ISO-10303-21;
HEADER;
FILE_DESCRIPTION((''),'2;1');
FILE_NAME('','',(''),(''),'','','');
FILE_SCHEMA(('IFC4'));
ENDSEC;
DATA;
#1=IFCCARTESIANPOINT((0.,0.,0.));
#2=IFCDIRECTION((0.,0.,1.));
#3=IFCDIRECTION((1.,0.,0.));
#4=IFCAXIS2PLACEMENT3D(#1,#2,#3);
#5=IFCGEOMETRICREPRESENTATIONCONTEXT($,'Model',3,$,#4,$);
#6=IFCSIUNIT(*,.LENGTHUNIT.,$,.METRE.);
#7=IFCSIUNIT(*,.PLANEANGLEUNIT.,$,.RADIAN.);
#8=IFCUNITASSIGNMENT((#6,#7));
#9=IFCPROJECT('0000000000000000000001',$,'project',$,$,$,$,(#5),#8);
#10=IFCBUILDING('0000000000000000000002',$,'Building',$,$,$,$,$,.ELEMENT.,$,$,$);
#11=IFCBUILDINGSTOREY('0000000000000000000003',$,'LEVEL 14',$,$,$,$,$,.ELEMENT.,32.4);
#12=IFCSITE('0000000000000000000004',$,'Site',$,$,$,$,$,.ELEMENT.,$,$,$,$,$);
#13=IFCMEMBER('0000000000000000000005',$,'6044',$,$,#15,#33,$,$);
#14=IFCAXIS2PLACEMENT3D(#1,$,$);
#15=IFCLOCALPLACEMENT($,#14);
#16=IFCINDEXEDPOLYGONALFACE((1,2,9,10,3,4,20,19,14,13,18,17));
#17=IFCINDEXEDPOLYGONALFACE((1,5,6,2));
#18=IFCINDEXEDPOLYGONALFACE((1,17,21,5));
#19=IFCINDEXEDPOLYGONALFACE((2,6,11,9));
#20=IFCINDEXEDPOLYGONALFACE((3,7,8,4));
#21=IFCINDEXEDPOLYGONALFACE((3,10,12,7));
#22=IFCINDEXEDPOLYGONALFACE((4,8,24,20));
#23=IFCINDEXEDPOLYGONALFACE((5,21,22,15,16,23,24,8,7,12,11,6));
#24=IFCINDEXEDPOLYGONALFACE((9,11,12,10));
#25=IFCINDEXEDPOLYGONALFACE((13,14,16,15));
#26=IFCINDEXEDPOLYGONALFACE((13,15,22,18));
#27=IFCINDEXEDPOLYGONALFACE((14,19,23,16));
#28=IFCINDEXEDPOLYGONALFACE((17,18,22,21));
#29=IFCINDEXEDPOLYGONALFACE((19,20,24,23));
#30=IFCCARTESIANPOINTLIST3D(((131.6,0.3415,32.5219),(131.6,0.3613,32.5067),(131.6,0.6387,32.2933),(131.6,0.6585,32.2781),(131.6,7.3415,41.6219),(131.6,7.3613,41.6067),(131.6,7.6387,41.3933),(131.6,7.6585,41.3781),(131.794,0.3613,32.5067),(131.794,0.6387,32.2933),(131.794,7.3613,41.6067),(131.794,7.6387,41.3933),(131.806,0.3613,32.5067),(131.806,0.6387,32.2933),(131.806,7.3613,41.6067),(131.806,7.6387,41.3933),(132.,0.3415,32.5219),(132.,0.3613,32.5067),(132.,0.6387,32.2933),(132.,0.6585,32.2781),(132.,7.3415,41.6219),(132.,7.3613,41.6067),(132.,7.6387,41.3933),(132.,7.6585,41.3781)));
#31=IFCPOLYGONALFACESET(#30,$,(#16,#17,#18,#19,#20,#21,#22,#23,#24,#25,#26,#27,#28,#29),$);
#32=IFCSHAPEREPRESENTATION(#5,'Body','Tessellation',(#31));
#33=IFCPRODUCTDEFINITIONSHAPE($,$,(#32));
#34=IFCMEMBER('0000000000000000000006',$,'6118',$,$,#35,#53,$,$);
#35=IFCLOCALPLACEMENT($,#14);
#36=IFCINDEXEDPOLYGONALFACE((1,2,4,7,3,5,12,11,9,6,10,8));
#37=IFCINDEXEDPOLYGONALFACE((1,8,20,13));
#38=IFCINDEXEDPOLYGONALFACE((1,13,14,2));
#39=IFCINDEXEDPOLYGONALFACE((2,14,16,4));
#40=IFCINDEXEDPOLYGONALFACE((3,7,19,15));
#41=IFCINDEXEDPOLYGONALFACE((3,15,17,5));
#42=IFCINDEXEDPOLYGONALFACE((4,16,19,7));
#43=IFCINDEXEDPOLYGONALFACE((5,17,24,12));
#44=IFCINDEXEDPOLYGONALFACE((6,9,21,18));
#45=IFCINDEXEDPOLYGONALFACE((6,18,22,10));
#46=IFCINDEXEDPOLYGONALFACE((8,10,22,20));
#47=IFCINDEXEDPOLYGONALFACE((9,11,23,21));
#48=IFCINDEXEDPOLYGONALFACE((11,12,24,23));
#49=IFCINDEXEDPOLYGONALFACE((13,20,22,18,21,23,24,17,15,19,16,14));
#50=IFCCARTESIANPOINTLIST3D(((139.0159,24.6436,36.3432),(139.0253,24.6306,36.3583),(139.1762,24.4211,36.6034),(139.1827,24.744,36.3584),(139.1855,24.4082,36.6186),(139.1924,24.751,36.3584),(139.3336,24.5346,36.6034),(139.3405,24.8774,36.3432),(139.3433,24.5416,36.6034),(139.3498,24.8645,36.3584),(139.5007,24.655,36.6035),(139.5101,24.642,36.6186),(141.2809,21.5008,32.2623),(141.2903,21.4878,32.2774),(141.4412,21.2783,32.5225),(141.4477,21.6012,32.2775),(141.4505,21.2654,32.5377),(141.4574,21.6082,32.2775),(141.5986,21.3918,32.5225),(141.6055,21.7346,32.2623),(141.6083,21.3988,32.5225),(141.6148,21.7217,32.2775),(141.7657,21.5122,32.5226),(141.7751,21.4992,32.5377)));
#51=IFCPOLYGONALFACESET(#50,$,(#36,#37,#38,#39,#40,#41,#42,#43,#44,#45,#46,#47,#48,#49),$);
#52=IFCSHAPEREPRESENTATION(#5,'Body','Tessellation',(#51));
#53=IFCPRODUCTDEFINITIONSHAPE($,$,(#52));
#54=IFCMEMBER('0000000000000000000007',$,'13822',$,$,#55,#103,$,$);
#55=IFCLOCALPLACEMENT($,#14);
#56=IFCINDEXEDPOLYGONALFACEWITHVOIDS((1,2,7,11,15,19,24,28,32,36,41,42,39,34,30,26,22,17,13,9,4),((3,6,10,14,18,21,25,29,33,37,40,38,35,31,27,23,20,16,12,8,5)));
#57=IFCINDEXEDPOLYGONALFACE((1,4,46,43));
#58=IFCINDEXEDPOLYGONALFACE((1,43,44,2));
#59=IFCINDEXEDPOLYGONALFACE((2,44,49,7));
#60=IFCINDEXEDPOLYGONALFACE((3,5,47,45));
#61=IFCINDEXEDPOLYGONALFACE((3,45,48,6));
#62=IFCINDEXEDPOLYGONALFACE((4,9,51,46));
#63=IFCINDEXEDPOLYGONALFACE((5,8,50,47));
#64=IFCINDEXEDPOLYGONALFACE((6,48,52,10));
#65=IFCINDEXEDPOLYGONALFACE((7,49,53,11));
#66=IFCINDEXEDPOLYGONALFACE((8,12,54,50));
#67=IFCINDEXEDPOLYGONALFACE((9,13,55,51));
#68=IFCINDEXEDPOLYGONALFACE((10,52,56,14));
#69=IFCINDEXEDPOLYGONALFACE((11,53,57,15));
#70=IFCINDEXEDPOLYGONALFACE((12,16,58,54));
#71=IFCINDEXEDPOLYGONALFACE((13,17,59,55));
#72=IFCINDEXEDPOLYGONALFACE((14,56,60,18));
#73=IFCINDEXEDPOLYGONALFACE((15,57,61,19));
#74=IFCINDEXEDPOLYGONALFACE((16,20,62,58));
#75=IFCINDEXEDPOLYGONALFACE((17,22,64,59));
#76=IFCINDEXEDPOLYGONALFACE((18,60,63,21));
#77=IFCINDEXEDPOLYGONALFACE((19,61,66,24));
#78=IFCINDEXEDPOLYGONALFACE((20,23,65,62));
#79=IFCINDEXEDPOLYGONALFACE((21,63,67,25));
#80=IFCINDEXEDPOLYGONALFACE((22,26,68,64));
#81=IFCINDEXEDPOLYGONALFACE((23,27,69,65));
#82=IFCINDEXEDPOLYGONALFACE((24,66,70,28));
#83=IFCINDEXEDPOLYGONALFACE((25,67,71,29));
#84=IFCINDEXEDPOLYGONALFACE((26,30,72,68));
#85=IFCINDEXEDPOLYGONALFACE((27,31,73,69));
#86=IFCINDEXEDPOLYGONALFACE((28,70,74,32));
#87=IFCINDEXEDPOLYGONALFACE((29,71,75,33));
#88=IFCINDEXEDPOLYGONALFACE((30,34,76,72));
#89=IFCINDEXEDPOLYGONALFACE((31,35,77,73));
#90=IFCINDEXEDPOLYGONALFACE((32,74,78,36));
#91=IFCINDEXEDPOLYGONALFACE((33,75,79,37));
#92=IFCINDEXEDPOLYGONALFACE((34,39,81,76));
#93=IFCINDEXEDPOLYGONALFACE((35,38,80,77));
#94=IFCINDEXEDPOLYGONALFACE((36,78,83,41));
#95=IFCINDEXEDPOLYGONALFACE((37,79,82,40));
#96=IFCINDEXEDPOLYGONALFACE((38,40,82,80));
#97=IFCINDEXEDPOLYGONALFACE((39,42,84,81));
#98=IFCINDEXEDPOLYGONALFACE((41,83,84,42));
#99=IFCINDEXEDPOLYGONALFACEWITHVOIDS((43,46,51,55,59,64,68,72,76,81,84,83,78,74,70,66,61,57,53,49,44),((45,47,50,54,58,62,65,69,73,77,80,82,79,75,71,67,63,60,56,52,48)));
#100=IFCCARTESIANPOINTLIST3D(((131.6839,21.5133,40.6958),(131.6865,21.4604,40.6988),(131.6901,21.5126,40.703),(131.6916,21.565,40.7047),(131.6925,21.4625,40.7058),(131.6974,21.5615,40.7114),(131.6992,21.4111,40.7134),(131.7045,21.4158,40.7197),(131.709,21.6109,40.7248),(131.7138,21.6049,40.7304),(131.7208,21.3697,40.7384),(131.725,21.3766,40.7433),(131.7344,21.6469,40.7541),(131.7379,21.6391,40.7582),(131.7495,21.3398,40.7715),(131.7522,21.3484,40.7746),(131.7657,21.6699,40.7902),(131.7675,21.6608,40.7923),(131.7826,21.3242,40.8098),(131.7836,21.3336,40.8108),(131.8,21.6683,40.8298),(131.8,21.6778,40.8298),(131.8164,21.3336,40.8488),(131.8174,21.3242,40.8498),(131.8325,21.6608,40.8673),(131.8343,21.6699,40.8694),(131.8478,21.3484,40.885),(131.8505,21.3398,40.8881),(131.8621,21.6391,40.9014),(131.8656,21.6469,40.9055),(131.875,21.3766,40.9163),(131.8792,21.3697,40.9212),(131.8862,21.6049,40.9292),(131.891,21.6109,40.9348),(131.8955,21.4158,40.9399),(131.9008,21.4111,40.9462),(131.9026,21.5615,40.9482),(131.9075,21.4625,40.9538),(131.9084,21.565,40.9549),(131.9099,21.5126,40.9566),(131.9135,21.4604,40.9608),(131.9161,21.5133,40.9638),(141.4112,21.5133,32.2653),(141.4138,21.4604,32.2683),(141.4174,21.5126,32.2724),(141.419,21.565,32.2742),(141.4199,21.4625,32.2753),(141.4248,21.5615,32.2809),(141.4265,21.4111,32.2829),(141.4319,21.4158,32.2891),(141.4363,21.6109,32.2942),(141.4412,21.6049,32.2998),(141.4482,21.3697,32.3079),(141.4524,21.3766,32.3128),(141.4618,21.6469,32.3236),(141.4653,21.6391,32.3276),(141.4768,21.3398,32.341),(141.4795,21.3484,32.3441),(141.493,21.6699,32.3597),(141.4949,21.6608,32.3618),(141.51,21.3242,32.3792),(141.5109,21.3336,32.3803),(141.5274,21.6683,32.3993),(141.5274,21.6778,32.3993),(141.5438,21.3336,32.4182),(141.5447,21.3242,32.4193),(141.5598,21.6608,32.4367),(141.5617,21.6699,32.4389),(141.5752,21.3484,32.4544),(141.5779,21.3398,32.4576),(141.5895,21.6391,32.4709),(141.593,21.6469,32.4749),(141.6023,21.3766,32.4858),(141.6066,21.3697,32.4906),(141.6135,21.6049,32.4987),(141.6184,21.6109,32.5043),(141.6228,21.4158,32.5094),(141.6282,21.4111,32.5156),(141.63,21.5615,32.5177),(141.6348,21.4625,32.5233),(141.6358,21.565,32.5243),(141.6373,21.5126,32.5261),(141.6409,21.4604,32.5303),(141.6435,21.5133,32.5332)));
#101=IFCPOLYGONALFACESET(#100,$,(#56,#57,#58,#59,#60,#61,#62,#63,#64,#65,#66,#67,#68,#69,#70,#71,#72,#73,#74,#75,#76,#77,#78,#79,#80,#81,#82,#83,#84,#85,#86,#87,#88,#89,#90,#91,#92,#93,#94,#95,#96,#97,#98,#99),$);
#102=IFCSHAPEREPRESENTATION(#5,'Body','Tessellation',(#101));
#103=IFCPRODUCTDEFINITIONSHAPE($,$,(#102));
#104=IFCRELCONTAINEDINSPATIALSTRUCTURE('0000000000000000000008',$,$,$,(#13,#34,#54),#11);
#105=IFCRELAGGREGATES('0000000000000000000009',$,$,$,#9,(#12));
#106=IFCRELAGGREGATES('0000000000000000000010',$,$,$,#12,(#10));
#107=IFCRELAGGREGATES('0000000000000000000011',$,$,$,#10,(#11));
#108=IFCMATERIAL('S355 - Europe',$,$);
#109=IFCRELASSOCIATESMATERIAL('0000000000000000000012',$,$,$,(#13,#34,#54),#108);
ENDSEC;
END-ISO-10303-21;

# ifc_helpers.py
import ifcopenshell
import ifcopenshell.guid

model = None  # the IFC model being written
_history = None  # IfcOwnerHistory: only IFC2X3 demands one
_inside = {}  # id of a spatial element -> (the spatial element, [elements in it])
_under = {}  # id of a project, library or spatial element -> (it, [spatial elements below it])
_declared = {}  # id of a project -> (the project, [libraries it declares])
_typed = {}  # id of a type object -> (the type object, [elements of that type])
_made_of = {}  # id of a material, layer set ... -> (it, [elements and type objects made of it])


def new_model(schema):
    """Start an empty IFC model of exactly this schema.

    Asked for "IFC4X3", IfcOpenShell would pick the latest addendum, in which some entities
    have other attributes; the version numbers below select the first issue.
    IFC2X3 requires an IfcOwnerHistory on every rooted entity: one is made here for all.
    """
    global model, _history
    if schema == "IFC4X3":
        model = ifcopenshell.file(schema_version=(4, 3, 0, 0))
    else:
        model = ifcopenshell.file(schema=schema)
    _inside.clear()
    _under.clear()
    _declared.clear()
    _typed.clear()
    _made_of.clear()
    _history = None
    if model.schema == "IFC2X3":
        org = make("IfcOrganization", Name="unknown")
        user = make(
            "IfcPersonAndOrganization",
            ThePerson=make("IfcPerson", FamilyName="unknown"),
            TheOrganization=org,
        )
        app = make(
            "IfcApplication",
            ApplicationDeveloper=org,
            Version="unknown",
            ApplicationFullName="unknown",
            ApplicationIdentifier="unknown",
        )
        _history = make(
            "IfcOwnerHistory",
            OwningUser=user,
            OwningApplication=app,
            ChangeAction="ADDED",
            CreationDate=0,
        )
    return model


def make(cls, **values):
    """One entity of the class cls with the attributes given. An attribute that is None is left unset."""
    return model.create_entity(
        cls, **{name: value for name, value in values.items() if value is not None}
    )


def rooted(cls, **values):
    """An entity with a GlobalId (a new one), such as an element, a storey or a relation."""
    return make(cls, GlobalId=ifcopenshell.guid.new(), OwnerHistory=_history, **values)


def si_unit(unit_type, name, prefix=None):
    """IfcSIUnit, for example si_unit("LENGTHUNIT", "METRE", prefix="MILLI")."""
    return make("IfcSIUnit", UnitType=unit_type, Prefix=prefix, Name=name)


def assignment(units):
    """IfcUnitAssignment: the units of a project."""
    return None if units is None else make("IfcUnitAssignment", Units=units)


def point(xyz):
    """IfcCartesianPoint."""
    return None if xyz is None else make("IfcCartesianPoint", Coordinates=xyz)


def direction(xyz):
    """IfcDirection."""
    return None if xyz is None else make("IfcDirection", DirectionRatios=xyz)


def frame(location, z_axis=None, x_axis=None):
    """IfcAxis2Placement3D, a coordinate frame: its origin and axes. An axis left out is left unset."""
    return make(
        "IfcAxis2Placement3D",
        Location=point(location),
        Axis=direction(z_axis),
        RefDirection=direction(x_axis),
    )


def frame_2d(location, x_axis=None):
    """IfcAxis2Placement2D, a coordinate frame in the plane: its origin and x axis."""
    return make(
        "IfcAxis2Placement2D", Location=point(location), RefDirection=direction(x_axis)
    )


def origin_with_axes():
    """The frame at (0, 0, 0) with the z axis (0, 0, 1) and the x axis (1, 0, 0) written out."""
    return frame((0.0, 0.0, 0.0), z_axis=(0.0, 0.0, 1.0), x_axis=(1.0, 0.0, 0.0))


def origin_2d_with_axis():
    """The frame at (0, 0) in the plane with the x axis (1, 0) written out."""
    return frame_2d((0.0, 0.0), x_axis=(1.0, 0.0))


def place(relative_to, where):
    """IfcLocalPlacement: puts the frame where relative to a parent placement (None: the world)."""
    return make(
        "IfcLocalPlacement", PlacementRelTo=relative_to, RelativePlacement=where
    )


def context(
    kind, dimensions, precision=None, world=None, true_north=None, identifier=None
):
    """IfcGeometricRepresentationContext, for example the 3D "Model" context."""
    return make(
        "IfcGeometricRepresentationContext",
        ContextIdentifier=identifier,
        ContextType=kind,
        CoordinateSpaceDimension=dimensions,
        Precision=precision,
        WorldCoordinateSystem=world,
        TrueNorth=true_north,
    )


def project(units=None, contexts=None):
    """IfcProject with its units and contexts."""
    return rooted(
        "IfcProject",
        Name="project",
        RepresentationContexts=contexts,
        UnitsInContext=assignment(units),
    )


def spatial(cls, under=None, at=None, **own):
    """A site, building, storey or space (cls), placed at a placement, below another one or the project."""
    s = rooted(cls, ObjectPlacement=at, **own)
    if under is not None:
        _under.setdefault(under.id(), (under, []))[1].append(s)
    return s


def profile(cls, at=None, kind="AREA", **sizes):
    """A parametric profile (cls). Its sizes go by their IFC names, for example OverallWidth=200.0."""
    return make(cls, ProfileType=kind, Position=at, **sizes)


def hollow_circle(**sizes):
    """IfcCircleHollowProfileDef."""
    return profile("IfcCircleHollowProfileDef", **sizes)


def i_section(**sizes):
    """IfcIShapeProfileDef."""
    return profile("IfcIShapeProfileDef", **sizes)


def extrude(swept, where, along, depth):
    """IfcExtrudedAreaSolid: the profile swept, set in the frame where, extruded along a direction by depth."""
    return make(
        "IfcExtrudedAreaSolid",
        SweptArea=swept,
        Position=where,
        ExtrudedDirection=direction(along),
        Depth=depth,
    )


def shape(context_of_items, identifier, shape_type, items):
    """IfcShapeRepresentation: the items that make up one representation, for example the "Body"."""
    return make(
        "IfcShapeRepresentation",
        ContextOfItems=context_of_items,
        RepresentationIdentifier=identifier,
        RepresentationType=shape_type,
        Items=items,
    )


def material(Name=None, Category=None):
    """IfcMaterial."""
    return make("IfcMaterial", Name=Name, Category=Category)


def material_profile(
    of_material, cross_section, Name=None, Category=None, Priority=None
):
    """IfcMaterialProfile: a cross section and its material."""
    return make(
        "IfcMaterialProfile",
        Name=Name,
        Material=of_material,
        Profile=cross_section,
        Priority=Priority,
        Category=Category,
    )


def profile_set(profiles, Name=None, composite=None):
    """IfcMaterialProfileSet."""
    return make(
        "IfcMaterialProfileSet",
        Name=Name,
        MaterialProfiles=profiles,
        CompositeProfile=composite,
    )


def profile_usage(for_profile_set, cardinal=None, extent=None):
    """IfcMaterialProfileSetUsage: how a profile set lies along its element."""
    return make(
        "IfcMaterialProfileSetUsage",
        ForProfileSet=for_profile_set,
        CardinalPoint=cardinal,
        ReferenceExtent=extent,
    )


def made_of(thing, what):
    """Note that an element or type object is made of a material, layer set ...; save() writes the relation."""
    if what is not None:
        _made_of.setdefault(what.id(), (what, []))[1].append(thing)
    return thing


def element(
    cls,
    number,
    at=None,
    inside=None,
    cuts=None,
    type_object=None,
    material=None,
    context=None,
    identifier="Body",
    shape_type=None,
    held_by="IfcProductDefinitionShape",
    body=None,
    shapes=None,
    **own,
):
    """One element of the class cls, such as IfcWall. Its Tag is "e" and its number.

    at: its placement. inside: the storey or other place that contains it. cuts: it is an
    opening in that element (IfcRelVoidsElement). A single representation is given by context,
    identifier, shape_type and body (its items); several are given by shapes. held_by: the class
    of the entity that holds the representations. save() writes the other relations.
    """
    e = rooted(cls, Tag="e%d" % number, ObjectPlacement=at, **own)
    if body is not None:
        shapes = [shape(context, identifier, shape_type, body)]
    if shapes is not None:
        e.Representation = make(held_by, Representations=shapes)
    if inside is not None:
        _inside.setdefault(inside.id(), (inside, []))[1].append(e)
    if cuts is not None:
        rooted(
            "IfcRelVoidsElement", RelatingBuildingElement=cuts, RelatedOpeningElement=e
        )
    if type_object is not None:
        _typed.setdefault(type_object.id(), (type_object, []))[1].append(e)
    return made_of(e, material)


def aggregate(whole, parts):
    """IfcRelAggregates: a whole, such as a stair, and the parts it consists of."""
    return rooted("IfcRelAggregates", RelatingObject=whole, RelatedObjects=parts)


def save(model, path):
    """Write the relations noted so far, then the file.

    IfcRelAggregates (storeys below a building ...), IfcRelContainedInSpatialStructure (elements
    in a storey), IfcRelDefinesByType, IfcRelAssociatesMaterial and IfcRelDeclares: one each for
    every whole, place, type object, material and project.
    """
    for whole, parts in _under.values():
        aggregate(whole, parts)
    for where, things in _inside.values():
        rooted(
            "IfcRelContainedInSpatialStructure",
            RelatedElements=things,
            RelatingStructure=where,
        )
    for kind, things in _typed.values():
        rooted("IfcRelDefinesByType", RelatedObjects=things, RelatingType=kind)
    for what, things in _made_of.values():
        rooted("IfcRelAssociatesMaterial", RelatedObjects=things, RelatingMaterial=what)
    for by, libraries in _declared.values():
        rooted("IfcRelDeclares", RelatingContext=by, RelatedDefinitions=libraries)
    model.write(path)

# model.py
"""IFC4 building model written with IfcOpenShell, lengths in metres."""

from ifc_helpers import new_model, si_unit, frame, origin_with_axes, origin_2d_with_axis, place, context, project, spatial, hollow_circle, i_section, extrude, material, material_profile, profile_set, profile_usage, element, save


model = new_model("IFC4")

# Units and contexts
model_context = context("Model", 3, world=origin_with_axes())
ifc_project = project(units=[si_unit("LENGTHUNIT", "METRE"), si_unit("PLANEANGLEUNIT", "RADIAN")], contexts=[model_context])

# Site, building, storey
site = spatial("IfcSite", under=ifc_project, Name="Site", CompositionType="ELEMENT")
building = spatial("IfcBuilding", under=site, Name="Building", CompositionType="ELEMENT")
storey = spatial("IfcBuildingStorey", under=building, Name="LEVEL 14", CompositionType="ELEMENT", Elevation=32.4)

# Shared definitions
ifc_material = material(Name="S355 - Europe")

# Members
ifc_material_profile_1 = material_profile(ifc_material, i_section(OverallWidth=0.4, OverallDepth=0.4, WebThickness=0.012, FlangeThickness=0.025, at=origin_2d_with_axis()))
ifc_profile_set_1 = profile_set([ifc_material_profile_1])
ifc_profile_usage_1 = profile_usage(ifc_profile_set_1, cardinal=10)
member_1_placement = place(None, frame((131.8, 0.5, 32.4), z_axis=(0.0, 0.609711, 0.792624), x_axis=(-1.0, 0.0, 0.0)))
element("IfcMember", 1, at=member_1_placement, inside=storey, material=ifc_profile_usage_1, Name="6044", context=model_context, shape_type="SweptSolid", body=[
    extrude(i_section(OverallWidth=0.4, OverallDepth=0.4, WebThickness=0.012, FlangeThickness=0.025, at=origin_2d_with_axis()), origin_with_axes(), (0.0, 0.0, 1.0), 11.4809),
])
ifc_material_profile_2 = material_profile(ifc_material, i_section(OverallWidth=0.4, OverallDepth=0.4, WebThickness=0.012, FlangeThickness=0.022, at=origin_2d_with_axis()))
ifc_profile_set_2 = profile_set([ifc_material_profile_2])
ifc_profile_usage_2 = profile_usage(ifc_profile_set_2, cardinal=10)
member_2_placement = place(None, frame((141.528, 21.5, 32.4), z_axis=(-0.402536, 0.558539, 0.725258), x_axis=(-0.811322, -0.584599, 0.0)))
element("IfcMember", 2, at=member_2_placement, inside=storey, material=ifc_profile_usage_2, Name="6118", context=model_context, shape_type="SweptSolid", body=[
    extrude(i_section(OverallWidth=0.4, OverallDepth=0.4, WebThickness=0.012, FlangeThickness=0.022, at=origin_2d_with_axis()), origin_with_axes(), (0.0, 0.0, 1.0), 5.6268),
])
ifc_material_profile_3 = material_profile(ifc_material, hollow_circle(Radius=0.1778, WallThickness=0.0095, at=origin_2d_with_axis()))
ifc_profile_set_3 = profile_set([ifc_material_profile_3])
ifc_profile_usage_3 = profile_usage(ifc_profile_set_3, cardinal=10)
member_3_placement = place(None, frame((131.8, 21.5, 40.8298), z_axis=(0.755683, 0.0, -0.654938), x_axis=(0.0, 1.0, 0.0)))
element("IfcMember", 3, at=member_3_placement, inside=storey, material=ifc_profile_usage_3, Name="13822", context=model_context, shape_type="SweptSolid", body=[
    extrude(hollow_circle(Radius=0.1778, WallThickness=0.0095, at=origin_2d_with_axis()), origin_with_axes(), (0.0, 0.0, 1.0), 12.8723),
])

save(model, "model.ifc")
